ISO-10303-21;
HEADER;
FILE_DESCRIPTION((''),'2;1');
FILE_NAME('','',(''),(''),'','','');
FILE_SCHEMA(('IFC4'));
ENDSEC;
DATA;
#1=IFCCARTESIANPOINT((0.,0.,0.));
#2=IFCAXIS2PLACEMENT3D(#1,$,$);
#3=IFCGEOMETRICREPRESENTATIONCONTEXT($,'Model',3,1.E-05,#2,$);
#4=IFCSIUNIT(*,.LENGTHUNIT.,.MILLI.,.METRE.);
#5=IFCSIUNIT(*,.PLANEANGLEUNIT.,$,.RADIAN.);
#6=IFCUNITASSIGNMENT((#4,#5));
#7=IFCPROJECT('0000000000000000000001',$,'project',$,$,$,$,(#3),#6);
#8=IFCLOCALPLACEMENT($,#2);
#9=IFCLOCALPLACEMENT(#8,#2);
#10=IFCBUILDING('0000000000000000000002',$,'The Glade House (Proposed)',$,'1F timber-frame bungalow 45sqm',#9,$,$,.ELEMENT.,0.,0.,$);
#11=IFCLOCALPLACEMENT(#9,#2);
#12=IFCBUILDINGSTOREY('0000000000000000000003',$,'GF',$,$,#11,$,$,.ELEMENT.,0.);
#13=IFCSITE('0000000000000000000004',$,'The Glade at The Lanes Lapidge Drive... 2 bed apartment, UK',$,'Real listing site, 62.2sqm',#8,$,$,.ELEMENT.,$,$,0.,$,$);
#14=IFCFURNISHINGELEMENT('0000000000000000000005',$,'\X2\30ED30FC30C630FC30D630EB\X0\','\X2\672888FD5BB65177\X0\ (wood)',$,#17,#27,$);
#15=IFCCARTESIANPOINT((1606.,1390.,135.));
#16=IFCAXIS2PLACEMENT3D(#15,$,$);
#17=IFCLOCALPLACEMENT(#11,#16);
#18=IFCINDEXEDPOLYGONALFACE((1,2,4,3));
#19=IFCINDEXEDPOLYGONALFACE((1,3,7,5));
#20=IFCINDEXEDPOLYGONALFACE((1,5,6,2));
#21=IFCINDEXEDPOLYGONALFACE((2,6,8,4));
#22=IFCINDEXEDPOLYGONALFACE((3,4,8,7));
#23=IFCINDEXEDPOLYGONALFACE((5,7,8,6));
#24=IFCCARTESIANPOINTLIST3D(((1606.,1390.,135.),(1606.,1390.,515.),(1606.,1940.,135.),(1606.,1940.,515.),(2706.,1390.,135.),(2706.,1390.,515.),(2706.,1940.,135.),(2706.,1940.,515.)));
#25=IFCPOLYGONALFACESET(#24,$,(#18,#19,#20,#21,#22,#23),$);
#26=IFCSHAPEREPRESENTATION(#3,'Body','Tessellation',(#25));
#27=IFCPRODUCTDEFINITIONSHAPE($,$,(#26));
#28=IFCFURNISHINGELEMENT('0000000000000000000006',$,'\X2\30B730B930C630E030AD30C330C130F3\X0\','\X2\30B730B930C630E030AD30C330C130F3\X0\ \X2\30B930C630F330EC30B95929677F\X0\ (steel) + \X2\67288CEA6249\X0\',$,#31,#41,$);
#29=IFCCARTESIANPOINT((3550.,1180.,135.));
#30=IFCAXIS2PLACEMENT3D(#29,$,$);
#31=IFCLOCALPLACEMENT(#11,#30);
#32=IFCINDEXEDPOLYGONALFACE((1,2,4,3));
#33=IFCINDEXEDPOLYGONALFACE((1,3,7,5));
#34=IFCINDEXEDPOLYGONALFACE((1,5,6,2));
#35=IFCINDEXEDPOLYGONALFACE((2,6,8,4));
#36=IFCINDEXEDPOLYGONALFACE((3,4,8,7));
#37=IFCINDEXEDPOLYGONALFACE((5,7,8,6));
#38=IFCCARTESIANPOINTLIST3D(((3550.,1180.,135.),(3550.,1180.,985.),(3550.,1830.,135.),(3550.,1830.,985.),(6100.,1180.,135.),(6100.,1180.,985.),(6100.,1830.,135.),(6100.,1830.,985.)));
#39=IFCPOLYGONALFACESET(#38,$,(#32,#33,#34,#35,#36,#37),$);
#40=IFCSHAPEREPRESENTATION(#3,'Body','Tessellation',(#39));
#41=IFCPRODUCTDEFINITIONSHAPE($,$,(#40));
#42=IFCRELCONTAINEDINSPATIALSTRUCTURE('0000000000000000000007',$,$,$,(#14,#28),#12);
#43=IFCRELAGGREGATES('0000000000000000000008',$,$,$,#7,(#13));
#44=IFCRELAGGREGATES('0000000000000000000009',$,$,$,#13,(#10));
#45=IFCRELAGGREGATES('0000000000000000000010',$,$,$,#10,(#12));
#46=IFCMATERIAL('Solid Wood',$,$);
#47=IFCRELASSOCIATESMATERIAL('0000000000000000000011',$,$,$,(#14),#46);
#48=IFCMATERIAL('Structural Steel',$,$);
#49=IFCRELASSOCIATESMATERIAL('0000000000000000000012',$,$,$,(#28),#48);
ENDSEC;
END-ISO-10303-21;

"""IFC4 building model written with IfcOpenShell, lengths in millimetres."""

from ifc_helpers import new_model, si_unit, frame, frame_2d, origin, place, context, project, spatial, rectangle, extrude, material, element, save


model = new_model("IFC4")

# Units and contexts
model_context = context("Model", 3, precision=1e-05, world=origin())
ifc_project = project(units=[si_unit("LENGTHUNIT", "METRE", prefix="MILLI"), si_unit("PLANEANGLEUNIT", "RADIAN")], contexts=[model_context])

# Site, building, storey
site_placement = place(None, origin())
site = spatial("IfcSite", under=ifc_project, at=site_placement, Name="The Glade at The Lanes Lapidge Drive... 2 bed apartment, UK", ObjectType="Real listing site, 62.2sqm", CompositionType="ELEMENT", RefElevation=0.0)
building_placement = place(site_placement, origin())
building = spatial("IfcBuilding", under=site, at=building_placement, Name="The Glade House (Proposed)", ObjectType="1F timber-frame bungalow 45sqm", CompositionType="ELEMENT", ElevationOfRefHeight=0.0, ElevationOfTerrain=0.0)
storey_placement = place(building_placement, origin())
storey = spatial("IfcBuildingStorey", under=building, at=storey_placement, Name="GF", CompositionType="ELEMENT", Elevation=0.0)

# Shared definitions
ifc_material_1 = material(Name="Solid Wood")

# Furnishing elements
furnishing_1_placement = place(storey_placement, frame((1606.0, 1390.0, 135.0)))
element("IfcFurnishingElement", 1, at=furnishing_1_placement, inside=storey, material=ifc_material_1, Name="ローテーブル", Description="木製家具 (wood)", context=model_context, shape_type="SweptSolid", body=[
    extrude(rectangle(XDim=1100.0, YDim=550.0, at=frame_2d((550.0, 275.0))), frame((1606.0, 1390.0, 135.0)), (0.0, 0.0, 1.0), 380.0),
])
ifc_material_2 = material(Name="Structural Steel")
furnishing_2_placement = place(storey_placement, frame((3550.0, 1180.0, 135.0)))
element("IfcFurnishingElement", 2, at=furnishing_2_placement, inside=storey, material=ifc_material_2, Name="システムキッチン", Description="システムキッチン ステンレス天板 (steel) + 木質扉", context=model_context, shape_type="SweptSolid", body=[
    extrude(rectangle(XDim=2550.0, YDim=650.0, at=frame_2d((1275.0, 325.0))), frame((3550.0, 1180.0, 135.0)), (0.0, 0.0, 1.0), 850.0),
])

save(model, "model.ifc")
